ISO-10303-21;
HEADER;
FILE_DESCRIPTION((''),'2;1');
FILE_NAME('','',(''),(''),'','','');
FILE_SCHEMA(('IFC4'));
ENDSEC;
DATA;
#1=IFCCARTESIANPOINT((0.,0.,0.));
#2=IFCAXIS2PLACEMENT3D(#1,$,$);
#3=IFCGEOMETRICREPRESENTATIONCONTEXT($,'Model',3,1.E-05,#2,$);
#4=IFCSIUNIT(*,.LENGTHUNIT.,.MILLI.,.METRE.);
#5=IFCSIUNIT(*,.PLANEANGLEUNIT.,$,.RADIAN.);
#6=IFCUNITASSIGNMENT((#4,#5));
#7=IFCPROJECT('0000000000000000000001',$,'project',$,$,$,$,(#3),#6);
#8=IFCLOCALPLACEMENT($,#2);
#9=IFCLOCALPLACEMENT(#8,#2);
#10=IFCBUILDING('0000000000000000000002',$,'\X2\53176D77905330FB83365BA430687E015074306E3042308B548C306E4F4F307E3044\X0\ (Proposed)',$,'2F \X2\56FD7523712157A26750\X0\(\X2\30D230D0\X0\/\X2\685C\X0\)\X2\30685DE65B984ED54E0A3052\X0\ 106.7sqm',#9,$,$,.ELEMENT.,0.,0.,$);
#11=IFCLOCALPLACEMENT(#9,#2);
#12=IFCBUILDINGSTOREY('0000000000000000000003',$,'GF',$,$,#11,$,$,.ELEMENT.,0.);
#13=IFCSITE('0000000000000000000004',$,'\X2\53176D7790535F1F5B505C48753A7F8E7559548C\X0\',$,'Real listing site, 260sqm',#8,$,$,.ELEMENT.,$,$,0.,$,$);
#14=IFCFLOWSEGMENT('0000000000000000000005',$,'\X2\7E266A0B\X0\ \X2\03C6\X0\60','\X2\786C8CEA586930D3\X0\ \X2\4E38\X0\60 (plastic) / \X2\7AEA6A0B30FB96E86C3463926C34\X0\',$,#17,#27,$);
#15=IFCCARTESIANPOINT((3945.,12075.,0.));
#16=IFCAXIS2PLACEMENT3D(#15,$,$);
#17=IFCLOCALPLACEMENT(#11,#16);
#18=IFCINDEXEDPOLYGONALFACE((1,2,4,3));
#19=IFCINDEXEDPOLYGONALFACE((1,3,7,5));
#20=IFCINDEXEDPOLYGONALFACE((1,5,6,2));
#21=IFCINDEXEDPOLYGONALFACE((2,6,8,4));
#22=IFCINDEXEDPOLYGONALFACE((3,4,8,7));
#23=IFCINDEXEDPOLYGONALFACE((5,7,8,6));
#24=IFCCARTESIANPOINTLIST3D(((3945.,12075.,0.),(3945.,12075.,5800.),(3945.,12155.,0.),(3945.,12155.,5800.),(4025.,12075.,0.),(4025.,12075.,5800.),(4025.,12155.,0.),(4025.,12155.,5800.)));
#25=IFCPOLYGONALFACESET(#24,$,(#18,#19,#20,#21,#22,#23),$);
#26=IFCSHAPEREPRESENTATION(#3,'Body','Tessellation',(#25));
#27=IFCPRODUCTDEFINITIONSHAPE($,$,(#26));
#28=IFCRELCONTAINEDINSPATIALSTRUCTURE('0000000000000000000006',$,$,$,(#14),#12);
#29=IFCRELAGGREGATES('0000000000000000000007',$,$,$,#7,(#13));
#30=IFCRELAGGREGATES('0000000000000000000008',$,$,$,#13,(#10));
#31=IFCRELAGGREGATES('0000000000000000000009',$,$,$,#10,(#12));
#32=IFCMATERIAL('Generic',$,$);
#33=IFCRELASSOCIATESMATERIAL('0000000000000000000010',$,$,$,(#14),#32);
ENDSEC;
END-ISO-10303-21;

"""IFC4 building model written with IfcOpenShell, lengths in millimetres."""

from ifc_helpers import new_model, si_unit, frame, frame_2d, origin, place, context, project, spatial, rectangle, extrude, material, element, save


model = new_model("IFC4")

# Units and contexts
model_context = context("Model", 3, precision=1e-05, world=origin())
ifc_project = project(units=[si_unit("LENGTHUNIT", "METRE", prefix="MILLI"), si_unit("PLANEANGLEUNIT", "RADIAN")], contexts=[model_context])

# Site, building, storey
site_placement = place(None, origin())
site = spatial("IfcSite", under=ifc_project, at=site_placement, Name="北海道弟子屈町美留和", ObjectType="Real listing site, 260sqm", CompositionType="ELEMENT", RefElevation=0.0)
building_placement = place(site_placement, origin())
building = spatial("IfcBuilding", under=site, at=building_placement, Name="北海道・茶室と縁側のある和の住まい (Proposed)", ObjectType="2F 国産無垢材(ヒバ/桜)と左官仕上げ 106.7sqm", CompositionType="ELEMENT", ElevationOfRefHeight=0.0, ElevationOfTerrain=0.0)
storey_placement = place(building_placement, origin())
storey = spatial("IfcBuildingStorey", under=building, at=storey_placement, Name="GF", CompositionType="ELEMENT", Elevation=0.0)

# Shared definitions
ifc_material_1 = material(Name="Generic")

# Flow segment
flow_segment_placement = place(storey_placement, frame((3945.0, 12075.0, 0.0)))
element("IfcFlowSegment", 1, at=flow_segment_placement, inside=storey, material=ifc_material_1, Name="縦樋 φ60", Description="硬質塩ビ 丸60 (plastic) / 竪樋・雨水排水", context=model_context, shape_type="SweptSolid", body=[
    extrude(rectangle(XDim=80.0, YDim=80.0, at=frame_2d((40.0, 40.0))), frame((3945.0, 12075.0, 0.0)), (0.0, 0.0, 1.0), 5800.0),
])

save(model, "model.ifc")
